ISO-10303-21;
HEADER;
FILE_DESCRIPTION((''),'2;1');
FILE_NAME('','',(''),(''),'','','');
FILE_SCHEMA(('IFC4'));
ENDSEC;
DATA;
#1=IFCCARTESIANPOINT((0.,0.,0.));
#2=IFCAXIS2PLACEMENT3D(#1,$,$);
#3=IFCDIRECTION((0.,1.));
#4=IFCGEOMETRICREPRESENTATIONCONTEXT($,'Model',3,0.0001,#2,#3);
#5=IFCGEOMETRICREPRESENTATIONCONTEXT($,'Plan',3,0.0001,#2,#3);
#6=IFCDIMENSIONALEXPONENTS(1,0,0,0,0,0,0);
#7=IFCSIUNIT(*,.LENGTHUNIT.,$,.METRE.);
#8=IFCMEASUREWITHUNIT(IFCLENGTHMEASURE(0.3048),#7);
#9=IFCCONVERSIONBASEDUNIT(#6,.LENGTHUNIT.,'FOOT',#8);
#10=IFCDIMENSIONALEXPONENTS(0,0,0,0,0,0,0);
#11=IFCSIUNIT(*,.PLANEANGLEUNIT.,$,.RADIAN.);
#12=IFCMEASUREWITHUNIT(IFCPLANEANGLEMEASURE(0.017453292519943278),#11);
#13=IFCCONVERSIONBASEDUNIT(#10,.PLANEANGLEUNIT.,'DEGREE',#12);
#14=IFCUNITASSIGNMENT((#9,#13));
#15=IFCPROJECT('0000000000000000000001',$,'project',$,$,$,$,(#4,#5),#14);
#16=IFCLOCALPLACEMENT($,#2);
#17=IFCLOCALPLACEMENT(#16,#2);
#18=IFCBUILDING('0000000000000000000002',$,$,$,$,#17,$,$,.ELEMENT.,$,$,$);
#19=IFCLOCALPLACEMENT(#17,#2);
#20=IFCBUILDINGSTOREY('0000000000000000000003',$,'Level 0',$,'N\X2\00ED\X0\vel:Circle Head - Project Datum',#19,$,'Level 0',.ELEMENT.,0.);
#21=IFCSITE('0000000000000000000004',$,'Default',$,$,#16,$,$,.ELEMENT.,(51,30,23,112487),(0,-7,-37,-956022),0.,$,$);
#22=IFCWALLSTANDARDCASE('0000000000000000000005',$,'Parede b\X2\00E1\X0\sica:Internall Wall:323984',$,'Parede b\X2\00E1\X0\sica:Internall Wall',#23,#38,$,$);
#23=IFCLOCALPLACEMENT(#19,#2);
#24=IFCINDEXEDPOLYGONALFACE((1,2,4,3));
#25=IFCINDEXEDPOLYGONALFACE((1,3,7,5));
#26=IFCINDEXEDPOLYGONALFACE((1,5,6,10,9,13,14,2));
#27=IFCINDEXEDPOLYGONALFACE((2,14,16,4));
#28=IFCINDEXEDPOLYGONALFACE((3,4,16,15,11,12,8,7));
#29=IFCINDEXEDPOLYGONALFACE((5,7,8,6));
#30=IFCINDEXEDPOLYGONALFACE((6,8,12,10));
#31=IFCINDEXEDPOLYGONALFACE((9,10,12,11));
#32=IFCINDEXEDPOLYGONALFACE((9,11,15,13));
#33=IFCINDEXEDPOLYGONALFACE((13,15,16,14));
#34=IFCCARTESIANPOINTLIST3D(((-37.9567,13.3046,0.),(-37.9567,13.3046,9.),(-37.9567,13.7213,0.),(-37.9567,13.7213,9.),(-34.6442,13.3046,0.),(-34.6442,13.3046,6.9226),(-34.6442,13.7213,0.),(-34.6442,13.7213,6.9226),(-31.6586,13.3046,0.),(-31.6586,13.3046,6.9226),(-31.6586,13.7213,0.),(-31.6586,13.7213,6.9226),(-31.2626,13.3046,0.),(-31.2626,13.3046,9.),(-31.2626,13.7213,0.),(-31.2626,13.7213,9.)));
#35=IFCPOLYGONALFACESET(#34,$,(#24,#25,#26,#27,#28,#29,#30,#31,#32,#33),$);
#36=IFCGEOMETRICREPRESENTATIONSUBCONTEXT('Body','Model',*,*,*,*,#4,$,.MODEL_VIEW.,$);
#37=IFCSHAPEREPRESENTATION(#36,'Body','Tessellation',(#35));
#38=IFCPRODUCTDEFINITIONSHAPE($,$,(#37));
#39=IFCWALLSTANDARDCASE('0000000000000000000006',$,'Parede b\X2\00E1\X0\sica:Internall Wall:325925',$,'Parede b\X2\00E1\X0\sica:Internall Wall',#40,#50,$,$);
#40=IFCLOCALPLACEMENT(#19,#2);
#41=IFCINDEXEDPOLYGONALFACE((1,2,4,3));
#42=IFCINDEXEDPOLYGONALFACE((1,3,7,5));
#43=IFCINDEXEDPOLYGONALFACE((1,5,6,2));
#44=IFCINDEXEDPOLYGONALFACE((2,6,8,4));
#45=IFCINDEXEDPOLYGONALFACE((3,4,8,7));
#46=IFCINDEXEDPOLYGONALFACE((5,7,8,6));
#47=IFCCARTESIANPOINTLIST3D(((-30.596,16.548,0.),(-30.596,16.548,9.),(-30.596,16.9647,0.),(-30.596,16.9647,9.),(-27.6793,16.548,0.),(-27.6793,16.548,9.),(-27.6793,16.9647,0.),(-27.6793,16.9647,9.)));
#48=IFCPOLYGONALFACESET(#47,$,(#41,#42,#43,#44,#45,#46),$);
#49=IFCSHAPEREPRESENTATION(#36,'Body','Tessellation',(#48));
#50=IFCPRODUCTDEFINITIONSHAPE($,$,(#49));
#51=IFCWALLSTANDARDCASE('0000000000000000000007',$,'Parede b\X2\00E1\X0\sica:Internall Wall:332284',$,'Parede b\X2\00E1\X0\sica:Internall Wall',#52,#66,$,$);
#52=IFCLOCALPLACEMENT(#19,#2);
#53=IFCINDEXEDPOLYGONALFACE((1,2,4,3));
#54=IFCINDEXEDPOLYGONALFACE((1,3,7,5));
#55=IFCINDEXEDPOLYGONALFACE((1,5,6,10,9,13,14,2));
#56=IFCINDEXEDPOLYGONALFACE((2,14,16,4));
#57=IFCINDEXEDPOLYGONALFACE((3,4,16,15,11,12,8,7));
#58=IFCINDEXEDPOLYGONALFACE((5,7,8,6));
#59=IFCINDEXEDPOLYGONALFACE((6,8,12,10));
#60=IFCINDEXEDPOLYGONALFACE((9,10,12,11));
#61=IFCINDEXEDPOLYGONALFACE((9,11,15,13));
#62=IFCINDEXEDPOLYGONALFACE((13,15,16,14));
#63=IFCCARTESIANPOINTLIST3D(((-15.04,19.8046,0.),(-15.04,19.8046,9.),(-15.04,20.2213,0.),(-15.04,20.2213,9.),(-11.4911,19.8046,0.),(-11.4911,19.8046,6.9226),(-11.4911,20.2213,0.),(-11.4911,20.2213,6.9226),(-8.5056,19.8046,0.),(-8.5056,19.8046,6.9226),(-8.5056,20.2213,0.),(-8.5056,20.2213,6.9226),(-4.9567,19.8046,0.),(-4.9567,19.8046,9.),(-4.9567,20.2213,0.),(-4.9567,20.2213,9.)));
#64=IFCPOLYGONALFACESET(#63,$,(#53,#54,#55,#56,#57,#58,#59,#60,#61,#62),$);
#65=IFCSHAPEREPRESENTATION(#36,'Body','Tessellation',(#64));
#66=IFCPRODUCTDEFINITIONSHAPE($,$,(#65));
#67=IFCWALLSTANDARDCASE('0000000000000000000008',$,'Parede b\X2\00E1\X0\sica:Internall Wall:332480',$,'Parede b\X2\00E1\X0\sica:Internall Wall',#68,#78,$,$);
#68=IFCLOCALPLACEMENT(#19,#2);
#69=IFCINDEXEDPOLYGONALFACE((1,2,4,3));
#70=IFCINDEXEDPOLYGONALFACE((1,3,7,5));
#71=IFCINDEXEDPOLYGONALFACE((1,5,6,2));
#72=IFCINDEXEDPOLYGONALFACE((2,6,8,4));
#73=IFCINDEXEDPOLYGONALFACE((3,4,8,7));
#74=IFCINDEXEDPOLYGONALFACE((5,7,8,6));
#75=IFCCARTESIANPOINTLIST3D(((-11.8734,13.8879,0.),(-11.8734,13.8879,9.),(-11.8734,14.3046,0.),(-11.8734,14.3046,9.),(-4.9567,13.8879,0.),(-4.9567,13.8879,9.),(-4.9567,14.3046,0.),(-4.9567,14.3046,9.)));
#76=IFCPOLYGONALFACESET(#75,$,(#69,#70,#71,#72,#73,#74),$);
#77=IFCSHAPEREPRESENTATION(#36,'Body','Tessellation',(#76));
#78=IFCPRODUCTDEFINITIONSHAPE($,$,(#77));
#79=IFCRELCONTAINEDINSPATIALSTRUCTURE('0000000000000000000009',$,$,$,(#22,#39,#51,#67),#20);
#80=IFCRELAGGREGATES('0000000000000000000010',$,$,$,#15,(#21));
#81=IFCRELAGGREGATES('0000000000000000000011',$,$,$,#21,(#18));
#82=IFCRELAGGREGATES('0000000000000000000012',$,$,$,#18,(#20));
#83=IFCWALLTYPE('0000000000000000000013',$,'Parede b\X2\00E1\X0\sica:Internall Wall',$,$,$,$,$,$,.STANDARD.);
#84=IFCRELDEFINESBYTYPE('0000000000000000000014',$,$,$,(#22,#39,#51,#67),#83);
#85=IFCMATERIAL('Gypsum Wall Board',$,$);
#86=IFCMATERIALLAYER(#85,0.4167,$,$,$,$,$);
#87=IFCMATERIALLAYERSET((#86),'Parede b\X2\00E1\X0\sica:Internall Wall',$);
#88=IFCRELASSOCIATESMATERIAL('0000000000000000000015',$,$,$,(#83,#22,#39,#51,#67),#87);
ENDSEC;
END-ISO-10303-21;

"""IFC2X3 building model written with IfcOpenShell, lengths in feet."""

from ifc_helpers import new_model, entity, si_unit, converted_unit, direction, frame, frame_2d, origin, place, context, subcontext, project, spatial, rectangle, extrude, material, layer, layer_set, layer_usage, type_object, element, save


model = new_model("IFC2X3")

# Units and contexts
model_context = context("Model", 3, precision=0.0001, world=origin(), true_north=direction((0.0, 1.0)))
plan_context = context("Plan", 3, precision=0.0001, world=origin(), true_north=direction((0.0, 1.0)))
body_context = subcontext(model_context, "Body", "Model", "MODEL_VIEW")
ifc_project = project(units=[converted_unit("LENGTHUNIT", "FOOT", entity("IfcLengthMeasure", 0.3048), si_unit("LENGTHUNIT", "METRE"), dimensions=[1, 0, 0, 0, 0, 0, 0]), converted_unit("PLANEANGLEUNIT", "DEGREE", entity("IfcPlaneAngleMeasure", 0.017453292519943278), si_unit("PLANEANGLEUNIT", "RADIAN"), dimensions=[0, 0, 0, 0, 0, 0, 0])], contexts=[model_context, plan_context])

# Site, building, storey
site_placement = place(None, origin())
site = spatial("IfcSite", under=ifc_project, at=site_placement, Name="Default", CompositionType="ELEMENT", RefLatitude=(51, 30, 23, 112487), RefLongitude=(0, -7, -37, -956022), RefElevation=0.0)
building_placement = place(site_placement, origin())
building = spatial("IfcBuilding", under=site, at=building_placement, CompositionType="ELEMENT")
storey_placement = place(building_placement, origin())
storey = spatial("IfcBuildingStorey", under=building, at=storey_placement, Name="Level 0", ObjectType="Nível:Circle Head - Project Datum", LongName="Level 0", CompositionType="ELEMENT", Elevation=0.0)

# Shared definitions
ifc_material_1 = material(Name="Gypsum Wall Board")
ifc_layer_1 = layer(ifc_material_1, 0.4167)
ifc_layer_set_1 = layer_set([ifc_layer_1], Name="Parede básica:Internall Wall")
wall_type_1 = type_object("IfcWallType", Name="Parede básica:Internall Wall", PredefinedType="STANDARD", material=ifc_layer_set_1)

# Wall, opening
ifc_layer_usage_1 = layer_usage(ifc_layer_set_1, "AXIS2", "POSITIVE", -0.2083)
wall_1_placement = place(storey_placement, frame((-37.9567, 13.5129, 0.0)))
wall_1 = element("IfcWallStandardCase", 1, at=wall_1_placement, inside=storey, type_object=wall_type_1, material=ifc_layer_usage_1, Name="Parede básica:Internall Wall:323984", ObjectType="Parede básica:Internall Wall", context=body_context, shape_type="SweptSolid", body=[
    extrude(rectangle(XDim=6.6941, YDim=0.4167, at=frame_2d((3.347, 0.0), x_axis=(1.0, 0.0))), origin(), (0.0, 0.0, 1.0), 9.0),
])
opening_1_placement = place(wall_1_placement, frame((3.3125, -0.2083, 0.0)))
element("IfcOpeningElement", 2, at=opening_1_placement, cuts=wall_1, ObjectType="Opening", context=body_context, shape_type="SweptSolid", body=[
    extrude(rectangle(XDim=6.9226, YDim=2.9856, at=frame_2d((3.4613, 1.4928), x_axis=(1.0, 0.0))), frame((0.0, 0.0, 0.0), z_axis=(0.0, 1.0, 0.0), x_axis=(0.0, 0.0, 1.0)), (0.0, 0.0, 1.0), 0.4167),
])

# Wall
ifc_layer_usage_2 = layer_usage(ifc_layer_set_1, "AXIS2", "POSITIVE", -0.2083)
wall_2_placement = place(storey_placement, frame((-27.6793, 16.7564, 0.0), z_axis=(0.0, 0.0, 1.0), x_axis=(-1.0, 0.0, 0.0)))
element("IfcWallStandardCase", 3, at=wall_2_placement, inside=storey, type_object=wall_type_1, material=ifc_layer_usage_2, Name="Parede básica:Internall Wall:325925", ObjectType="Parede básica:Internall Wall", context=body_context, shape_type="SweptSolid", body=[
    extrude(rectangle(XDim=2.9167, YDim=0.4167, at=frame_2d((1.4583, 0.0), x_axis=(-1.0, 0.0))), origin(), (0.0, 0.0, 1.0), 9.0),
])

# Wall, opening
ifc_layer_usage_3 = layer_usage(ifc_layer_set_1, "AXIS2", "POSITIVE", -0.2083)
wall_3_placement = place(storey_placement, frame((-4.9567, 20.0129, 0.0), z_axis=(0.0, 0.0, 1.0), x_axis=(-1.0, 0.0, 0.0)))
wall_3 = element("IfcWallStandardCase", 4, at=wall_3_placement, inside=storey, type_object=wall_type_1, material=ifc_layer_usage_3, Name="Parede básica:Internall Wall:332284", ObjectType="Parede básica:Internall Wall", context=body_context, shape_type="SweptSolid", body=[
    extrude(rectangle(XDim=10.0833, YDim=0.4167, at=frame_2d((5.0417, 0.0), x_axis=(1.0, 0.0))), origin(), (0.0, 0.0, 1.0), 9.0),
])
opening_2_placement = place(wall_3_placement, frame((3.5489, -0.2083, 0.0)))
element("IfcOpeningElement", 5, at=opening_2_placement, cuts=wall_3, ObjectType="Opening", context=body_context, shape_type="SweptSolid", body=[
    extrude(rectangle(XDim=6.9226, YDim=2.9856, at=frame_2d((3.4613, 1.4928), x_axis=(1.0, 0.0))), frame((0.0, 0.0, 0.0), z_axis=(0.0, 1.0, 0.0), x_axis=(0.0, 0.0, 1.0)), (0.0, 0.0, 1.0), 0.4167),
])

# Wall
ifc_layer_usage_4 = layer_usage(ifc_layer_set_1, "AXIS2", "POSITIVE", -0.2083)
wall_4_placement = place(storey_placement, frame((-4.9567, 14.0963, 0.0), z_axis=(0.0, 0.0, 1.0), x_axis=(-1.0, 0.0, 0.0)))
element("IfcWallStandardCase", 6, at=wall_4_placement, inside=storey, type_object=wall_type_1, material=ifc_layer_usage_4, Name="Parede básica:Internall Wall:332480", ObjectType="Parede básica:Internall Wall", context=body_context, shape_type="SweptSolid", body=[
    extrude(rectangle(XDim=6.9167, YDim=0.4167, at=frame_2d((3.4583, 0.0), x_axis=(-1.0, 0.0))), origin(), (0.0, 0.0, 1.0), 9.0),
])

save(model, "model.ifc")
